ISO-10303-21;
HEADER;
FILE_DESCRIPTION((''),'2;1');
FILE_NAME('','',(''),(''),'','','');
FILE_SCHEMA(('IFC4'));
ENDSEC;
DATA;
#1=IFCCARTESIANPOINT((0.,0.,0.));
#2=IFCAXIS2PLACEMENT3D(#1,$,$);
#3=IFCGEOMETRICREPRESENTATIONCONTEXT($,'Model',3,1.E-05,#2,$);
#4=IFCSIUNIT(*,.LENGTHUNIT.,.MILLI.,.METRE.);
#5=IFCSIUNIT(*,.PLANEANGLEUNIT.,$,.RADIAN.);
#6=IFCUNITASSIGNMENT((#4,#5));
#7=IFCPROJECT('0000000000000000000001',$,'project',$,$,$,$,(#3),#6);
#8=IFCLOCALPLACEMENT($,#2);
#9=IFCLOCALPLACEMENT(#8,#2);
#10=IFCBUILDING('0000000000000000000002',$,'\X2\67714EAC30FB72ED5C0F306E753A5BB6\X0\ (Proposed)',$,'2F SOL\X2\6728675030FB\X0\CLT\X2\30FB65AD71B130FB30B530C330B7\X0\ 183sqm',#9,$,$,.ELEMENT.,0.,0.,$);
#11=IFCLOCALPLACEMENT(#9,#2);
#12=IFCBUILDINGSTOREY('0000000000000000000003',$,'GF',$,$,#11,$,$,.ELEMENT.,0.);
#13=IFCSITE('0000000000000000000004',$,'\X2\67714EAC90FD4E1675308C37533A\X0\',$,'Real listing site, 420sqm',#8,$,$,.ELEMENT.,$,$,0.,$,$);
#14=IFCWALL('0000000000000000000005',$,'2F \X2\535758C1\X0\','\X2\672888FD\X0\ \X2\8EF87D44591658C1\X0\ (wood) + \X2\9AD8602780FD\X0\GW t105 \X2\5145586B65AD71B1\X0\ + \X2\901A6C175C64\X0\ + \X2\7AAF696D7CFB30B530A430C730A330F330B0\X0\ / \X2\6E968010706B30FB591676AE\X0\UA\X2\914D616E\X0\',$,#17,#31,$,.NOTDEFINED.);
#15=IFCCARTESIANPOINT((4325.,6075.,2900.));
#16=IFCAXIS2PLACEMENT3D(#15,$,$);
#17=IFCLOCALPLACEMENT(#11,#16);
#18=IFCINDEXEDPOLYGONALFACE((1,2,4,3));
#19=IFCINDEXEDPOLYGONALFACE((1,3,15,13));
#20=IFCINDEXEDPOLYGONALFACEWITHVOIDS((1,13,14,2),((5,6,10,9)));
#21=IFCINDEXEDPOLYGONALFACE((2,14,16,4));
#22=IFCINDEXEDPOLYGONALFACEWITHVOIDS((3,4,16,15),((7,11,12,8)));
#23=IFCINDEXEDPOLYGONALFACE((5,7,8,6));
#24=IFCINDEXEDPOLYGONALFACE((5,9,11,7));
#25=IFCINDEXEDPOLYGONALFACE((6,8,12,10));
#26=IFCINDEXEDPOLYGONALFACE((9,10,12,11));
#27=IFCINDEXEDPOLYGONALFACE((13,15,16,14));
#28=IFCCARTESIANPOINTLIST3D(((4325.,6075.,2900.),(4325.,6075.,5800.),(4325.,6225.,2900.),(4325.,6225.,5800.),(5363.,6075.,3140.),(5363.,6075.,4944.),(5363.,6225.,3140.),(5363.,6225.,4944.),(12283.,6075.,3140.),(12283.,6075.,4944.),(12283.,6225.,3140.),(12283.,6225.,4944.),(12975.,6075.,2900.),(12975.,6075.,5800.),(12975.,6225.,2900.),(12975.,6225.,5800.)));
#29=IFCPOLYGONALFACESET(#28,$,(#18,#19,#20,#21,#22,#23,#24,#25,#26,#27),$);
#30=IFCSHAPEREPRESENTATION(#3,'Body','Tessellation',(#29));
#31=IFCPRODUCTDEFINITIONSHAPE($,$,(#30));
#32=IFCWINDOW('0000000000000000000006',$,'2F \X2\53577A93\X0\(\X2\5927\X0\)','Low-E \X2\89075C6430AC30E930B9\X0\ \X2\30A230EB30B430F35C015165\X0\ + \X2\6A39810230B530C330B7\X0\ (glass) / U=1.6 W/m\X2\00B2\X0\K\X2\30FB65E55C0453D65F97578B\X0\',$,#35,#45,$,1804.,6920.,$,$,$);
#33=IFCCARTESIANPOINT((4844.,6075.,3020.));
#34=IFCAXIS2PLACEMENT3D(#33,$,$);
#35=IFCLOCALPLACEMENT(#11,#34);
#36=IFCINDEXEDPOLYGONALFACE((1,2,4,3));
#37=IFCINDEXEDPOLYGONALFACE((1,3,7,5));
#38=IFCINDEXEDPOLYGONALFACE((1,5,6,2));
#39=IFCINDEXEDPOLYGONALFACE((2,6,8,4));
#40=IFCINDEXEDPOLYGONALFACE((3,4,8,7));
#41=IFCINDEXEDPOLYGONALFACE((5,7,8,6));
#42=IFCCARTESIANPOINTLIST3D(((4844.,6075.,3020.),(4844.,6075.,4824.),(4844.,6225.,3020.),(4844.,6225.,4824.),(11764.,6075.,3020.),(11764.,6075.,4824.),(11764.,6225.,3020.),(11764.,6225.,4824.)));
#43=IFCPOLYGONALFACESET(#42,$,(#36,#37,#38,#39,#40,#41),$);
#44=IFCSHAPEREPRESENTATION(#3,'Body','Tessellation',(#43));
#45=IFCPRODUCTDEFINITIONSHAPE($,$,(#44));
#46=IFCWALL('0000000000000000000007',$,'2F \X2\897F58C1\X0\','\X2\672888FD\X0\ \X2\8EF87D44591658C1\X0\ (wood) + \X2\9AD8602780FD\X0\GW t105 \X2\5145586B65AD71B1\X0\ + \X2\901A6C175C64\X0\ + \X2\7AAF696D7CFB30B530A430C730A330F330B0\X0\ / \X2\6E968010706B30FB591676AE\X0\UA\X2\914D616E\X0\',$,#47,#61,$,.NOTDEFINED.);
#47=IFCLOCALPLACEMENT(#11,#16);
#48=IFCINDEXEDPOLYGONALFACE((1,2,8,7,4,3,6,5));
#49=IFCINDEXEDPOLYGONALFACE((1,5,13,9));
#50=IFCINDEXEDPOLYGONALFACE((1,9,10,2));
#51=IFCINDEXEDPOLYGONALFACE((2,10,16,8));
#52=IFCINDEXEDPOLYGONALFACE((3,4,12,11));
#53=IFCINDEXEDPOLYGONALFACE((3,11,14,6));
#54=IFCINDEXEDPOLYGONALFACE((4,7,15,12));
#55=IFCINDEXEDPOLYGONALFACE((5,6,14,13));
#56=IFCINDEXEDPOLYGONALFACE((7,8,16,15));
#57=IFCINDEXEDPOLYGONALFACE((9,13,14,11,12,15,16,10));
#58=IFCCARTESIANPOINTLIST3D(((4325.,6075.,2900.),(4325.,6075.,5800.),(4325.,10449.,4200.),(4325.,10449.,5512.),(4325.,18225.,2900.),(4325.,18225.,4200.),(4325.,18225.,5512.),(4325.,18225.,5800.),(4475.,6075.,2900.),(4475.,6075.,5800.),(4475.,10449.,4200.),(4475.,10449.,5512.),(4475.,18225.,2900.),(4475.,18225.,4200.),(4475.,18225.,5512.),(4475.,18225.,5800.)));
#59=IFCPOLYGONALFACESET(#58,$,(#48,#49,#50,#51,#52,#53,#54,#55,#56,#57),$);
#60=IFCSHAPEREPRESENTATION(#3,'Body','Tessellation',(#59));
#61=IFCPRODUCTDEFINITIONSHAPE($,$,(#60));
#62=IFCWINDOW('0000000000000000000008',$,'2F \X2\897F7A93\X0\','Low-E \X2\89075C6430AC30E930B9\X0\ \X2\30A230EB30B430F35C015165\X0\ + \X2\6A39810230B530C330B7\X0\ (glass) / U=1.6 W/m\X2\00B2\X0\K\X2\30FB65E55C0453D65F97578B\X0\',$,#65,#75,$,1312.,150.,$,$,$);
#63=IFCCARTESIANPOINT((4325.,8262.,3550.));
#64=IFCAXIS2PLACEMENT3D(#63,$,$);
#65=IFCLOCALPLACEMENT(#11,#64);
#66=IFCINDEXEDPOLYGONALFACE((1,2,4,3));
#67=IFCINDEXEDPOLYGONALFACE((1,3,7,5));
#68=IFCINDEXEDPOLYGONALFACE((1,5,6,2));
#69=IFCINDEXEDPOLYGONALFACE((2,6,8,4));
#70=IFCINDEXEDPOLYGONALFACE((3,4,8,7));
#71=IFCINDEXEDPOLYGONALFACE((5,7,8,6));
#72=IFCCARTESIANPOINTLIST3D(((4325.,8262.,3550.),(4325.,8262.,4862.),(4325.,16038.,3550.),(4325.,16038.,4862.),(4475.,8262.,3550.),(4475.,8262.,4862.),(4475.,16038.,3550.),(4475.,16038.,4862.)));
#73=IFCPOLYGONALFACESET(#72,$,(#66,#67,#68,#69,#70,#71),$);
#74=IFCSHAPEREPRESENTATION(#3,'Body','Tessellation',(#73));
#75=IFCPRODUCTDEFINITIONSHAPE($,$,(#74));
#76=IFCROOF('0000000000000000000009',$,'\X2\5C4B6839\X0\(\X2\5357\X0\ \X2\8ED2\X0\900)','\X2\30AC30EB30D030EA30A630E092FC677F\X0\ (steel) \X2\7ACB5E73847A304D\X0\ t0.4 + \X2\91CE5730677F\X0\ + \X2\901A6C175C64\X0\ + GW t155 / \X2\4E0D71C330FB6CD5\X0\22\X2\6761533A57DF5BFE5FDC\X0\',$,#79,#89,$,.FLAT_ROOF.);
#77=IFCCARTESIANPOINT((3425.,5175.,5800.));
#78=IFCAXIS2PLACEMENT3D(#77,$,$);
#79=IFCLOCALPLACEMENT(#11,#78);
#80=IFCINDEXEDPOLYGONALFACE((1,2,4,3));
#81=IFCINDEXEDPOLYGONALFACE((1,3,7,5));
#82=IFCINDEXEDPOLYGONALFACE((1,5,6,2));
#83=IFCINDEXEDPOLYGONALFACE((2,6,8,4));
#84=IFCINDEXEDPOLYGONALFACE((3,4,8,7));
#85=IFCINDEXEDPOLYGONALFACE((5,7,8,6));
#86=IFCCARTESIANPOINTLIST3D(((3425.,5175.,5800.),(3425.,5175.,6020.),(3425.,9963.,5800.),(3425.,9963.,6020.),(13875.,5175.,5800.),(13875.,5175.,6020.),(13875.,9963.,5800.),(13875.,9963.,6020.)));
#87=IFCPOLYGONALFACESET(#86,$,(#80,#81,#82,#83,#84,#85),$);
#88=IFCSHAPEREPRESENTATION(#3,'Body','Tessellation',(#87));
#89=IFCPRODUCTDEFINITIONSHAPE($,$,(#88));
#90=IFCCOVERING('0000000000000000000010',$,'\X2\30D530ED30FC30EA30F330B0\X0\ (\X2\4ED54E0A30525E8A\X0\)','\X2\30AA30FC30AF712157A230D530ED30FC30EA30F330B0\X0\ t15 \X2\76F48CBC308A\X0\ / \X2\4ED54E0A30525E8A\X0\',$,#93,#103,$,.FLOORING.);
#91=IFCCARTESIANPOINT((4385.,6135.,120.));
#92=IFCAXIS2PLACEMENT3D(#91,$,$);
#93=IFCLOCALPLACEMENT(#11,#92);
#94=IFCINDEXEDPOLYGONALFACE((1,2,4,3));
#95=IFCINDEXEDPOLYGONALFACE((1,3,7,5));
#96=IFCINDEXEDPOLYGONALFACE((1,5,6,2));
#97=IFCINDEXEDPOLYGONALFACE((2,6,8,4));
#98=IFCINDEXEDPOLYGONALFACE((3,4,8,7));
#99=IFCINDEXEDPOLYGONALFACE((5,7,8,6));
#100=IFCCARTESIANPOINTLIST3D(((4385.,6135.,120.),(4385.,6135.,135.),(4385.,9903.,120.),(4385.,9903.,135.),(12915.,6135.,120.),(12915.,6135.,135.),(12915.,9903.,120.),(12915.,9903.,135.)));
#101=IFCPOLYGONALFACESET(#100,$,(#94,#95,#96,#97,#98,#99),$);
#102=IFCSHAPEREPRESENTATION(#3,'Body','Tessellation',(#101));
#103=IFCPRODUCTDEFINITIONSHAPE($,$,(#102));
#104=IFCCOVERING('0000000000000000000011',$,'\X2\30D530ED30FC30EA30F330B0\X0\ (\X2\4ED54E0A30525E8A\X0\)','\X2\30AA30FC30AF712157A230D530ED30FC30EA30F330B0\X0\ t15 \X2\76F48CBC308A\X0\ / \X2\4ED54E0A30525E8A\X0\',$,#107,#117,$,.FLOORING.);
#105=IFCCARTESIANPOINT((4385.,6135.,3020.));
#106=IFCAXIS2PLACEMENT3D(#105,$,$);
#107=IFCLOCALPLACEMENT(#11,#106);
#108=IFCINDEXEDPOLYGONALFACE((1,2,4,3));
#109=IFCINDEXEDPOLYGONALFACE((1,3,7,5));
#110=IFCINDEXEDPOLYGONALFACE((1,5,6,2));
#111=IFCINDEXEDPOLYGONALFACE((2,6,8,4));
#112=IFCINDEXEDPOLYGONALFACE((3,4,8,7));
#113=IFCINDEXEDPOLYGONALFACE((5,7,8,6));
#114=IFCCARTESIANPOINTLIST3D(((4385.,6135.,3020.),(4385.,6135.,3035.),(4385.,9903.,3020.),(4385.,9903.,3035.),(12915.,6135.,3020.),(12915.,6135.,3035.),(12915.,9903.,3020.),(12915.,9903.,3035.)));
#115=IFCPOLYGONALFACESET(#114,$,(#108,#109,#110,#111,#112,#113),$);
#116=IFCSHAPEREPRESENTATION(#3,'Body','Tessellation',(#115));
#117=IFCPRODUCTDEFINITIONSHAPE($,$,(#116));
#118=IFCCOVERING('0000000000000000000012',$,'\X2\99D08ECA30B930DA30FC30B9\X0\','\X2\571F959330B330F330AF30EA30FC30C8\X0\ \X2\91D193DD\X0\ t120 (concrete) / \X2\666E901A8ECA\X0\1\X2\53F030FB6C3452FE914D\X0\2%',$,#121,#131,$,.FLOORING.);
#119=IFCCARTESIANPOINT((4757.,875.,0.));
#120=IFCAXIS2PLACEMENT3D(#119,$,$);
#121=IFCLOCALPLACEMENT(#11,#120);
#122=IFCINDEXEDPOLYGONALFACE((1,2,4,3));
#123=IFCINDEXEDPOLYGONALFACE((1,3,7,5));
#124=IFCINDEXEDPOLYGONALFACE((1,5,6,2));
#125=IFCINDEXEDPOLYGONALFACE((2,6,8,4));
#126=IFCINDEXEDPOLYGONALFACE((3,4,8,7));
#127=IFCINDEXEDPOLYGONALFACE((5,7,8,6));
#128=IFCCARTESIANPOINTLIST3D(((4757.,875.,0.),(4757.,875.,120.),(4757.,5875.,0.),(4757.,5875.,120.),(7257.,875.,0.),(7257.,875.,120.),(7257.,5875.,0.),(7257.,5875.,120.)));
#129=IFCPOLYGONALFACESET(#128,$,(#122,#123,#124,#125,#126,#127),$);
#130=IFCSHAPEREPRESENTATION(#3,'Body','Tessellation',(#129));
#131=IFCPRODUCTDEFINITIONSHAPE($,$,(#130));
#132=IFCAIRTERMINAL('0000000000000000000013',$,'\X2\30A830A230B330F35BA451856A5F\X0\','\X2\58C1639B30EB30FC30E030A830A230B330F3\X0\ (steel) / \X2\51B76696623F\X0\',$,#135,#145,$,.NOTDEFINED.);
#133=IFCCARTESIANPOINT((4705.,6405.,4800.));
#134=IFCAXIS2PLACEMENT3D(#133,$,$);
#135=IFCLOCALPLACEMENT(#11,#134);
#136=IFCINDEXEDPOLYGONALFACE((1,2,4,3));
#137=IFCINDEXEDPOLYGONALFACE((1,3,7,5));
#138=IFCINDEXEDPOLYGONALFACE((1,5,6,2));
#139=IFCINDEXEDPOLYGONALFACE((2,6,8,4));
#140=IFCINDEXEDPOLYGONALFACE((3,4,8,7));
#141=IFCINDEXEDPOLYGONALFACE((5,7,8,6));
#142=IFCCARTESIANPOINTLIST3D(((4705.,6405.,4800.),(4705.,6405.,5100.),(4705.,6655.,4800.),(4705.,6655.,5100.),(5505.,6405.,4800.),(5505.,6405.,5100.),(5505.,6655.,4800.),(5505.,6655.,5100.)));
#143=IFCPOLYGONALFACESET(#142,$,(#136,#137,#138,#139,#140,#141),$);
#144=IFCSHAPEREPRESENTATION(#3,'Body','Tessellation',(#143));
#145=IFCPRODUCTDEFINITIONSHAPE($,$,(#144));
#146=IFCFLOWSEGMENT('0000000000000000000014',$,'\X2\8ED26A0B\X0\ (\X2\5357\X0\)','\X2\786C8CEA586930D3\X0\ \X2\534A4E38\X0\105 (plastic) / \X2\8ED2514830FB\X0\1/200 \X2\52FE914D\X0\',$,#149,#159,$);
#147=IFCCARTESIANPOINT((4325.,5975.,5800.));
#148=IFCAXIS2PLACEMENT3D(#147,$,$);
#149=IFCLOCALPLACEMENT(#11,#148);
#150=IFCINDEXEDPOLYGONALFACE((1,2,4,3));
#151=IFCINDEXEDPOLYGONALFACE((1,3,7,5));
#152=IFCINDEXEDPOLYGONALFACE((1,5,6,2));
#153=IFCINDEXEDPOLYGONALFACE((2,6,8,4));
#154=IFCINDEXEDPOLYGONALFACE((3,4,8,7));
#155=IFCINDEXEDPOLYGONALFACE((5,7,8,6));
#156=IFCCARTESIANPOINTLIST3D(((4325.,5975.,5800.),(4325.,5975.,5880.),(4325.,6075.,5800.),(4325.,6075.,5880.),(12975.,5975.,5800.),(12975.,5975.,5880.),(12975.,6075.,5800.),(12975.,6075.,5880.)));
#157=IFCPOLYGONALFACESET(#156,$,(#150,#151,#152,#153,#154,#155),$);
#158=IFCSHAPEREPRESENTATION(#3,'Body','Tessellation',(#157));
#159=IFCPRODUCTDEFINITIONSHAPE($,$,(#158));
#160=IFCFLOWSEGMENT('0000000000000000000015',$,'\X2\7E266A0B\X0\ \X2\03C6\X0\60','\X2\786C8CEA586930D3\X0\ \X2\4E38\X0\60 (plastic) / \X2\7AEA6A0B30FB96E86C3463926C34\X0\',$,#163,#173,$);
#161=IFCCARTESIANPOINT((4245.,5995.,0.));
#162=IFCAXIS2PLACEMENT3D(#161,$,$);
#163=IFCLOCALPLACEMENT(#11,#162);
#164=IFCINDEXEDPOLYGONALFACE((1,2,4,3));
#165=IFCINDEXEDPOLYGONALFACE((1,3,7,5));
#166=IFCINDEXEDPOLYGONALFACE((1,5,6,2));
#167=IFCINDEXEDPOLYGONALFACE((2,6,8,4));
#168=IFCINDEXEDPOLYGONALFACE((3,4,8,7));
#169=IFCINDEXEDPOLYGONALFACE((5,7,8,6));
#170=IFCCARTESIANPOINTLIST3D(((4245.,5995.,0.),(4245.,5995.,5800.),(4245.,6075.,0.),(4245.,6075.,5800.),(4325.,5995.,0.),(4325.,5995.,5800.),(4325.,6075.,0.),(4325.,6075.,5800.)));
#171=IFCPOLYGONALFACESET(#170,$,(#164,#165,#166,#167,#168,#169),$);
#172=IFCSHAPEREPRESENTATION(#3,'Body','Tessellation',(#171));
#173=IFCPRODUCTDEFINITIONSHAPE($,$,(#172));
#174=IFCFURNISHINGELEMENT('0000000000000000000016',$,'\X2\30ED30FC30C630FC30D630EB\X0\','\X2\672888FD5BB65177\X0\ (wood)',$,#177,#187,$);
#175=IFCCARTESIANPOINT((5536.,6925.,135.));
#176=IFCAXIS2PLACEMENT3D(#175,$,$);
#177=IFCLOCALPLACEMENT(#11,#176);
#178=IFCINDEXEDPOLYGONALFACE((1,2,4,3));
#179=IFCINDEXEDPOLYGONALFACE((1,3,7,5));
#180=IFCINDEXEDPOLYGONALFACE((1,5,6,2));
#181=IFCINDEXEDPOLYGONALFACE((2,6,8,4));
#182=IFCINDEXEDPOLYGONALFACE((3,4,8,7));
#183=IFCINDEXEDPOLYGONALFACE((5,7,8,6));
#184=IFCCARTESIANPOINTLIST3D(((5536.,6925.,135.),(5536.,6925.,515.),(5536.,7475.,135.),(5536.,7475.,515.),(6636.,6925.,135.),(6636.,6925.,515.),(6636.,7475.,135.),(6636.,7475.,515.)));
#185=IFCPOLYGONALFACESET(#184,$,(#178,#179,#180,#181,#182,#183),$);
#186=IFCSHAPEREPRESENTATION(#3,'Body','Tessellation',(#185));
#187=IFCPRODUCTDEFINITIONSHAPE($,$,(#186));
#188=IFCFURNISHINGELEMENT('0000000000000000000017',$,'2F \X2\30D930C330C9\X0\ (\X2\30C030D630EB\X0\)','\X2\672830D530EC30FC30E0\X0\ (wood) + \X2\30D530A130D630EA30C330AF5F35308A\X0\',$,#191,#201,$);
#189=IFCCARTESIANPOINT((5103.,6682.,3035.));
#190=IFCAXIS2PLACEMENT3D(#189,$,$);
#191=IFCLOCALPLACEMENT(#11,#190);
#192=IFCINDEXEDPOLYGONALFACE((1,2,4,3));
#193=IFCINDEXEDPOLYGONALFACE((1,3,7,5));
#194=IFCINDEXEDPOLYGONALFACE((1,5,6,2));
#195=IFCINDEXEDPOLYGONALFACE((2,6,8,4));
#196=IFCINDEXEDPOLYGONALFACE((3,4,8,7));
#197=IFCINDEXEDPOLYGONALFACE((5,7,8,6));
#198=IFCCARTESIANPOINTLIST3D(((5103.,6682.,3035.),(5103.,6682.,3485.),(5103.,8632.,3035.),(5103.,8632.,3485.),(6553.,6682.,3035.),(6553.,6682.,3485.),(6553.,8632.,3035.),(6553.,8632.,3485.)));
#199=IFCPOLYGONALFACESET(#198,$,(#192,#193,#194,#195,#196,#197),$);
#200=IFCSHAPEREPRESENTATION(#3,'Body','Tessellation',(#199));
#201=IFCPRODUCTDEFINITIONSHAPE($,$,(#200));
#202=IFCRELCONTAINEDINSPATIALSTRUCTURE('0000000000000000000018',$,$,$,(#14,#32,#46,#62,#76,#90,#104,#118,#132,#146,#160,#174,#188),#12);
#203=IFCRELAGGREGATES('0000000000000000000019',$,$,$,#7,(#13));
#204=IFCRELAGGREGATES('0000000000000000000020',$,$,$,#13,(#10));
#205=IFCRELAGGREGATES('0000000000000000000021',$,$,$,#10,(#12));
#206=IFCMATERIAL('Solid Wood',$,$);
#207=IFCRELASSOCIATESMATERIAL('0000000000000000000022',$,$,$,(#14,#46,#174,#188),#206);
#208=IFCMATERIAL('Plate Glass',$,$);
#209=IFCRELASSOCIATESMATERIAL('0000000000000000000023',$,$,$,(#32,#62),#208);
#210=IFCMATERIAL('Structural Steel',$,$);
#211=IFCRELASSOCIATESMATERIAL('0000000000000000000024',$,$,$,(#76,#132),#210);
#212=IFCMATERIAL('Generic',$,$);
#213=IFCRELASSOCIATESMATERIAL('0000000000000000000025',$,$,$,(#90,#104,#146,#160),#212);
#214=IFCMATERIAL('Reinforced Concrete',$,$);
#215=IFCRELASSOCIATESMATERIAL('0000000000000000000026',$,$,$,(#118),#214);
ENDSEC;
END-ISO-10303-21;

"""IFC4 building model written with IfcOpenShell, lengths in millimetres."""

from ifc_helpers import new_model, si_unit, frame, frame_2d, origin, place, context, project, spatial, rectangle, extrude, material, element, fill, save


model = new_model("IFC4")

# Units and contexts
model_context = context("Model", 3, precision=1e-05, world=origin())
ifc_project = project(units=[si_unit("LENGTHUNIT", "METRE", prefix="MILLI"), si_unit("PLANEANGLEUNIT", "RADIAN")], contexts=[model_context])

# Site, building, storey
site_placement = place(None, origin())
site = spatial("IfcSite", under=ifc_project, at=site_placement, Name="東京都世田谷区", ObjectType="Real listing site, 420sqm", CompositionType="ELEMENT", RefElevation=0.0)
building_placement = place(site_placement, origin())
building = spatial("IfcBuilding", under=site, at=building_placement, Name="東京・狭小の町家 (Proposed)", ObjectType="2F SOL木材・CLT・断熱・サッシ 183sqm", CompositionType="ELEMENT", ElevationOfRefHeight=0.0, ElevationOfTerrain=0.0)
storey_placement = place(building_placement, origin())
storey = spatial("IfcBuildingStorey", under=building, at=storey_placement, Name="GF", CompositionType="ELEMENT", Elevation=0.0)

# Shared definitions
ifc_material_1 = material(Name="Solid Wood")

# Shared definitions
ifc_material_2 = material(Name="Reinforced Concrete")

# Shared definitions
ifc_material_3 = material(Name="Plate Glass")

# Walls, openings, windows
wall_1_placement = place(storey_placement, frame((4325.0, 6075.0, 2900.0)))
wall_1 = element("IfcWall", 1, at=wall_1_placement, inside=storey, material=ifc_material_1, Name="2F 南壁", Description="木製 軸組外壁 (wood) + 高性能GW t105 充填断熱 + 通気層 + 窯業系サイディング / 準耐火・外皮UA配慮", PredefinedType="NOTDEFINED", context=model_context, shape_type="SweptSolid", body=[
    extrude(rectangle(XDim=8650.0, YDim=150.0, at=frame_2d((4325.0, 75.0))), frame((4325.0, 6075.0, 2900.0)), (0.0, 0.0, 1.0), 2900.0),
])
opening_1_placement = place(storey_placement, frame((4844.0, 6075.0, 3020.0)))
opening_1 = element("IfcOpeningElement", 2, at=opening_1_placement, cuts=wall_1, PredefinedType="NOTDEFINED", context=model_context, shape_type="SweptSolid", body=[
    extrude(rectangle(XDim=6920.0, YDim=150.0, at=frame_2d((3460.0, 75.0))), frame((4844.0, 6075.0, 3020.0)), (0.0, 0.0, 1.0), 1804.0),
])
window_1_placement = place(storey_placement, frame((4844.0, 6075.0, 3020.0)))
window_1 = element("IfcWindow", 3, at=window_1_placement, inside=storey, material=ifc_material_3, Name="2F 南窓(大)", Description="Low-E 複層ガラス アルゴン封入 + 樹脂サッシ (glass) / U=1.6 W/m²K・日射取得型", OverallHeight=1804.0, OverallWidth=6920.0, context=model_context, shape_type="SweptSolid", body=[
    extrude(rectangle(XDim=6920.0, YDim=150.0, at=frame_2d((3460.0, 75.0))), frame((4844.0, 6075.0, 3020.0)), (0.0, 0.0, 1.0), 1804.0),
])
fill(opening_1, window_1)
wall_2_placement = place(storey_placement, frame((4325.0, 6075.0, 2900.0)))
wall_2 = element("IfcWall", 4, at=wall_2_placement, inside=storey, material=ifc_material_1, Name="2F 西壁", Description="木製 軸組外壁 (wood) + 高性能GW t105 充填断熱 + 通気層 + 窯業系サイディング / 準耐火・外皮UA配慮", PredefinedType="NOTDEFINED", context=model_context, shape_type="SweptSolid", body=[
    extrude(rectangle(XDim=150.0, YDim=12150.0, at=frame_2d((75.0, 6075.0))), frame((4325.0, 6075.0, 2900.0)), (0.0, 0.0, 1.0), 2900.0),
])
opening_2_placement = place(storey_placement, frame((4325.0, 8262.0, 3550.0)))
opening_2 = element("IfcOpeningElement", 5, at=opening_2_placement, cuts=wall_2, PredefinedType="NOTDEFINED", context=model_context, shape_type="SweptSolid", body=[
    extrude(rectangle(XDim=150.0, YDim=7776.0, at=frame_2d((75.0, 3888.0))), frame((4325.0, 8262.0, 3550.0)), (0.0, 0.0, 1.0), 1312.0),
])
window_2_placement = place(storey_placement, frame((4325.0, 8262.0, 3550.0)))
window_2 = element("IfcWindow", 6, at=window_2_placement, inside=storey, material=ifc_material_3, Name="2F 西窓", Description="Low-E 複層ガラス アルゴン封入 + 樹脂サッシ (glass) / U=1.6 W/m²K・日射取得型", OverallHeight=1312.0, OverallWidth=150.0, context=model_context, shape_type="SweptSolid", body=[
    extrude(rectangle(XDim=150.0, YDim=7776.0, at=frame_2d((75.0, 3888.0))), frame((4325.0, 8262.0, 3550.0)), (0.0, 0.0, 1.0), 1312.0),
])
fill(opening_2, window_2)

# Roof
ifc_material_4 = material(Name="Structural Steel")
for number, where, name in (
    (7, (3425.0, 5175.0, 5800.0), "屋根(南 軒900)"),
):
    element("IfcRoof", number, at=place(storey_placement, frame(where)), inside=storey, material=ifc_material_4, Name=name, Description="ガルバリウム鋼板 (steel) 立平葺き t0.4 + 野地板 + 通気層 + GW t155 / 不燃・法22条区域対応", PredefinedType="FLAT_ROOF", context=model_context, shape_type="SweptSolid", body=[
        extrude(rectangle(XDim=10450.0, YDim=4788.0, at=frame_2d((5225.0, 2394.0))), frame((3425.0, 5175.0, 5800.0)), (0.0, 0.0, 1.0), 220.0),
    ])

# Coverings
ifc_material_5 = material(Name="Generic")
covering_1_placement = place(storey_placement, frame((4385.0, 6135.0, 120.0)))
element("IfcCovering", 8, at=covering_1_placement, inside=storey, material=ifc_material_5, Name="フローリング (仕上げ床)", Description="オーク無垢フローリング t15 直貼り / 仕上げ床", PredefinedType="FLOORING", context=model_context, shape_type="SweptSolid", body=[
    extrude(rectangle(XDim=8530.0, YDim=3768.0, at=frame_2d((4265.0, 1884.0))), frame((4385.0, 6135.0, 120.0)), (0.0, 0.0, 1.0), 15.0),
])
covering_2_placement = place(storey_placement, frame((4385.0, 6135.0, 3020.0)))
element("IfcCovering", 9, at=covering_2_placement, inside=storey, material=ifc_material_5, Name="フローリング (仕上げ床)", Description="オーク無垢フローリング t15 直貼り / 仕上げ床", PredefinedType="FLOORING", context=model_context, shape_type="SweptSolid", body=[
    extrude(rectangle(XDim=8530.0, YDim=3768.0, at=frame_2d((4265.0, 1884.0))), frame((4385.0, 6135.0, 3020.0)), (0.0, 0.0, 1.0), 15.0),
])
covering_3_placement = place(storey_placement, frame((4757.0, 875.0, 0.0)))
element("IfcCovering", 10, at=covering_3_placement, inside=storey, material=ifc_material_2, Name="駐車スペース", Description="土間コンクリート 金鏝 t120 (concrete) / 普通車1台・水勾配2%", PredefinedType="FLOORING", context=model_context, shape_type="SweptSolid", body=[
    extrude(rectangle(XDim=2500.0, YDim=5000.0, at=frame_2d((1250.0, 2500.0))), frame((4757.0, 875.0, 0.0)), (0.0, 0.0, 1.0), 120.0),
])

# Air terminal
air_terminal_placement = place(storey_placement, frame((4705.0, 6405.0, 4800.0)))
element("IfcAirTerminal", 11, at=air_terminal_placement, inside=storey, material=ifc_material_4, Name="エアコン室内機", Description="壁掛ルームエアコン (steel) / 冷暖房", PredefinedType="NOTDEFINED", context=model_context, shape_type="SweptSolid", body=[
    extrude(rectangle(XDim=800.0, YDim=250.0, at=frame_2d((400.0, 125.0))), frame((4705.0, 6405.0, 4800.0)), (0.0, 0.0, 1.0), 300.0),
])

# Flow segments
flow_segment_1_placement = place(storey_placement, frame((4325.0, 5975.0, 5800.0)))
element("IfcFlowSegment", 12, at=flow_segment_1_placement, inside=storey, material=ifc_material_5, Name="軒樋 (南)", Description="硬質塩ビ 半丸105 (plastic) / 軒先・1/200 勾配", context=model_context, shape_type="SweptSolid", body=[
    extrude(rectangle(XDim=8650.0, YDim=100.0, at=frame_2d((4325.0, 50.0))), frame((4325.0, 5975.0, 5800.0)), (0.0, 0.0, 1.0), 80.0),
])
flow_segment_2_placement = place(storey_placement, frame((4245.0, 5995.0, 0.0)))
element("IfcFlowSegment", 13, at=flow_segment_2_placement, inside=storey, material=ifc_material_5, Name="縦樋 φ60", Description="硬質塩ビ 丸60 (plastic) / 竪樋・雨水排水", context=model_context, shape_type="SweptSolid", body=[
    extrude(rectangle(XDim=80.0, YDim=80.0, at=frame_2d((40.0, 40.0))), frame((4245.0, 5995.0, 0.0)), (0.0, 0.0, 1.0), 5800.0),
])

# Furnishing elements
furnishing_1_placement = place(storey_placement, frame((5536.0, 6925.0, 135.0)))
element("IfcFurnishingElement", 14, at=furnishing_1_placement, inside=storey, material=ifc_material_1, Name="ローテーブル", Description="木製家具 (wood)", context=model_context, shape_type="SweptSolid", body=[
    extrude(rectangle(XDim=1100.0, YDim=550.0, at=frame_2d((550.0, 275.0))), frame((5536.0, 6925.0, 135.0)), (0.0, 0.0, 1.0), 380.0),
])
furnishing_2_placement = place(storey_placement, frame((5103.0, 6682.0, 3035.0)))
element("IfcFurnishingElement", 15, at=furnishing_2_placement, inside=storey, material=ifc_material_1, Name="2F ベッド (ダブル)", Description="木フレーム (wood) + ファブリック張り", context=model_context, shape_type="SweptSolid", body=[
    extrude(rectangle(XDim=1450.0, YDim=1950.0, at=frame_2d((725.0, 975.0))), frame((5103.0, 6682.0, 3035.0)), (0.0, 0.0, 1.0), 450.0),
])

save(model, "model.ifc")
